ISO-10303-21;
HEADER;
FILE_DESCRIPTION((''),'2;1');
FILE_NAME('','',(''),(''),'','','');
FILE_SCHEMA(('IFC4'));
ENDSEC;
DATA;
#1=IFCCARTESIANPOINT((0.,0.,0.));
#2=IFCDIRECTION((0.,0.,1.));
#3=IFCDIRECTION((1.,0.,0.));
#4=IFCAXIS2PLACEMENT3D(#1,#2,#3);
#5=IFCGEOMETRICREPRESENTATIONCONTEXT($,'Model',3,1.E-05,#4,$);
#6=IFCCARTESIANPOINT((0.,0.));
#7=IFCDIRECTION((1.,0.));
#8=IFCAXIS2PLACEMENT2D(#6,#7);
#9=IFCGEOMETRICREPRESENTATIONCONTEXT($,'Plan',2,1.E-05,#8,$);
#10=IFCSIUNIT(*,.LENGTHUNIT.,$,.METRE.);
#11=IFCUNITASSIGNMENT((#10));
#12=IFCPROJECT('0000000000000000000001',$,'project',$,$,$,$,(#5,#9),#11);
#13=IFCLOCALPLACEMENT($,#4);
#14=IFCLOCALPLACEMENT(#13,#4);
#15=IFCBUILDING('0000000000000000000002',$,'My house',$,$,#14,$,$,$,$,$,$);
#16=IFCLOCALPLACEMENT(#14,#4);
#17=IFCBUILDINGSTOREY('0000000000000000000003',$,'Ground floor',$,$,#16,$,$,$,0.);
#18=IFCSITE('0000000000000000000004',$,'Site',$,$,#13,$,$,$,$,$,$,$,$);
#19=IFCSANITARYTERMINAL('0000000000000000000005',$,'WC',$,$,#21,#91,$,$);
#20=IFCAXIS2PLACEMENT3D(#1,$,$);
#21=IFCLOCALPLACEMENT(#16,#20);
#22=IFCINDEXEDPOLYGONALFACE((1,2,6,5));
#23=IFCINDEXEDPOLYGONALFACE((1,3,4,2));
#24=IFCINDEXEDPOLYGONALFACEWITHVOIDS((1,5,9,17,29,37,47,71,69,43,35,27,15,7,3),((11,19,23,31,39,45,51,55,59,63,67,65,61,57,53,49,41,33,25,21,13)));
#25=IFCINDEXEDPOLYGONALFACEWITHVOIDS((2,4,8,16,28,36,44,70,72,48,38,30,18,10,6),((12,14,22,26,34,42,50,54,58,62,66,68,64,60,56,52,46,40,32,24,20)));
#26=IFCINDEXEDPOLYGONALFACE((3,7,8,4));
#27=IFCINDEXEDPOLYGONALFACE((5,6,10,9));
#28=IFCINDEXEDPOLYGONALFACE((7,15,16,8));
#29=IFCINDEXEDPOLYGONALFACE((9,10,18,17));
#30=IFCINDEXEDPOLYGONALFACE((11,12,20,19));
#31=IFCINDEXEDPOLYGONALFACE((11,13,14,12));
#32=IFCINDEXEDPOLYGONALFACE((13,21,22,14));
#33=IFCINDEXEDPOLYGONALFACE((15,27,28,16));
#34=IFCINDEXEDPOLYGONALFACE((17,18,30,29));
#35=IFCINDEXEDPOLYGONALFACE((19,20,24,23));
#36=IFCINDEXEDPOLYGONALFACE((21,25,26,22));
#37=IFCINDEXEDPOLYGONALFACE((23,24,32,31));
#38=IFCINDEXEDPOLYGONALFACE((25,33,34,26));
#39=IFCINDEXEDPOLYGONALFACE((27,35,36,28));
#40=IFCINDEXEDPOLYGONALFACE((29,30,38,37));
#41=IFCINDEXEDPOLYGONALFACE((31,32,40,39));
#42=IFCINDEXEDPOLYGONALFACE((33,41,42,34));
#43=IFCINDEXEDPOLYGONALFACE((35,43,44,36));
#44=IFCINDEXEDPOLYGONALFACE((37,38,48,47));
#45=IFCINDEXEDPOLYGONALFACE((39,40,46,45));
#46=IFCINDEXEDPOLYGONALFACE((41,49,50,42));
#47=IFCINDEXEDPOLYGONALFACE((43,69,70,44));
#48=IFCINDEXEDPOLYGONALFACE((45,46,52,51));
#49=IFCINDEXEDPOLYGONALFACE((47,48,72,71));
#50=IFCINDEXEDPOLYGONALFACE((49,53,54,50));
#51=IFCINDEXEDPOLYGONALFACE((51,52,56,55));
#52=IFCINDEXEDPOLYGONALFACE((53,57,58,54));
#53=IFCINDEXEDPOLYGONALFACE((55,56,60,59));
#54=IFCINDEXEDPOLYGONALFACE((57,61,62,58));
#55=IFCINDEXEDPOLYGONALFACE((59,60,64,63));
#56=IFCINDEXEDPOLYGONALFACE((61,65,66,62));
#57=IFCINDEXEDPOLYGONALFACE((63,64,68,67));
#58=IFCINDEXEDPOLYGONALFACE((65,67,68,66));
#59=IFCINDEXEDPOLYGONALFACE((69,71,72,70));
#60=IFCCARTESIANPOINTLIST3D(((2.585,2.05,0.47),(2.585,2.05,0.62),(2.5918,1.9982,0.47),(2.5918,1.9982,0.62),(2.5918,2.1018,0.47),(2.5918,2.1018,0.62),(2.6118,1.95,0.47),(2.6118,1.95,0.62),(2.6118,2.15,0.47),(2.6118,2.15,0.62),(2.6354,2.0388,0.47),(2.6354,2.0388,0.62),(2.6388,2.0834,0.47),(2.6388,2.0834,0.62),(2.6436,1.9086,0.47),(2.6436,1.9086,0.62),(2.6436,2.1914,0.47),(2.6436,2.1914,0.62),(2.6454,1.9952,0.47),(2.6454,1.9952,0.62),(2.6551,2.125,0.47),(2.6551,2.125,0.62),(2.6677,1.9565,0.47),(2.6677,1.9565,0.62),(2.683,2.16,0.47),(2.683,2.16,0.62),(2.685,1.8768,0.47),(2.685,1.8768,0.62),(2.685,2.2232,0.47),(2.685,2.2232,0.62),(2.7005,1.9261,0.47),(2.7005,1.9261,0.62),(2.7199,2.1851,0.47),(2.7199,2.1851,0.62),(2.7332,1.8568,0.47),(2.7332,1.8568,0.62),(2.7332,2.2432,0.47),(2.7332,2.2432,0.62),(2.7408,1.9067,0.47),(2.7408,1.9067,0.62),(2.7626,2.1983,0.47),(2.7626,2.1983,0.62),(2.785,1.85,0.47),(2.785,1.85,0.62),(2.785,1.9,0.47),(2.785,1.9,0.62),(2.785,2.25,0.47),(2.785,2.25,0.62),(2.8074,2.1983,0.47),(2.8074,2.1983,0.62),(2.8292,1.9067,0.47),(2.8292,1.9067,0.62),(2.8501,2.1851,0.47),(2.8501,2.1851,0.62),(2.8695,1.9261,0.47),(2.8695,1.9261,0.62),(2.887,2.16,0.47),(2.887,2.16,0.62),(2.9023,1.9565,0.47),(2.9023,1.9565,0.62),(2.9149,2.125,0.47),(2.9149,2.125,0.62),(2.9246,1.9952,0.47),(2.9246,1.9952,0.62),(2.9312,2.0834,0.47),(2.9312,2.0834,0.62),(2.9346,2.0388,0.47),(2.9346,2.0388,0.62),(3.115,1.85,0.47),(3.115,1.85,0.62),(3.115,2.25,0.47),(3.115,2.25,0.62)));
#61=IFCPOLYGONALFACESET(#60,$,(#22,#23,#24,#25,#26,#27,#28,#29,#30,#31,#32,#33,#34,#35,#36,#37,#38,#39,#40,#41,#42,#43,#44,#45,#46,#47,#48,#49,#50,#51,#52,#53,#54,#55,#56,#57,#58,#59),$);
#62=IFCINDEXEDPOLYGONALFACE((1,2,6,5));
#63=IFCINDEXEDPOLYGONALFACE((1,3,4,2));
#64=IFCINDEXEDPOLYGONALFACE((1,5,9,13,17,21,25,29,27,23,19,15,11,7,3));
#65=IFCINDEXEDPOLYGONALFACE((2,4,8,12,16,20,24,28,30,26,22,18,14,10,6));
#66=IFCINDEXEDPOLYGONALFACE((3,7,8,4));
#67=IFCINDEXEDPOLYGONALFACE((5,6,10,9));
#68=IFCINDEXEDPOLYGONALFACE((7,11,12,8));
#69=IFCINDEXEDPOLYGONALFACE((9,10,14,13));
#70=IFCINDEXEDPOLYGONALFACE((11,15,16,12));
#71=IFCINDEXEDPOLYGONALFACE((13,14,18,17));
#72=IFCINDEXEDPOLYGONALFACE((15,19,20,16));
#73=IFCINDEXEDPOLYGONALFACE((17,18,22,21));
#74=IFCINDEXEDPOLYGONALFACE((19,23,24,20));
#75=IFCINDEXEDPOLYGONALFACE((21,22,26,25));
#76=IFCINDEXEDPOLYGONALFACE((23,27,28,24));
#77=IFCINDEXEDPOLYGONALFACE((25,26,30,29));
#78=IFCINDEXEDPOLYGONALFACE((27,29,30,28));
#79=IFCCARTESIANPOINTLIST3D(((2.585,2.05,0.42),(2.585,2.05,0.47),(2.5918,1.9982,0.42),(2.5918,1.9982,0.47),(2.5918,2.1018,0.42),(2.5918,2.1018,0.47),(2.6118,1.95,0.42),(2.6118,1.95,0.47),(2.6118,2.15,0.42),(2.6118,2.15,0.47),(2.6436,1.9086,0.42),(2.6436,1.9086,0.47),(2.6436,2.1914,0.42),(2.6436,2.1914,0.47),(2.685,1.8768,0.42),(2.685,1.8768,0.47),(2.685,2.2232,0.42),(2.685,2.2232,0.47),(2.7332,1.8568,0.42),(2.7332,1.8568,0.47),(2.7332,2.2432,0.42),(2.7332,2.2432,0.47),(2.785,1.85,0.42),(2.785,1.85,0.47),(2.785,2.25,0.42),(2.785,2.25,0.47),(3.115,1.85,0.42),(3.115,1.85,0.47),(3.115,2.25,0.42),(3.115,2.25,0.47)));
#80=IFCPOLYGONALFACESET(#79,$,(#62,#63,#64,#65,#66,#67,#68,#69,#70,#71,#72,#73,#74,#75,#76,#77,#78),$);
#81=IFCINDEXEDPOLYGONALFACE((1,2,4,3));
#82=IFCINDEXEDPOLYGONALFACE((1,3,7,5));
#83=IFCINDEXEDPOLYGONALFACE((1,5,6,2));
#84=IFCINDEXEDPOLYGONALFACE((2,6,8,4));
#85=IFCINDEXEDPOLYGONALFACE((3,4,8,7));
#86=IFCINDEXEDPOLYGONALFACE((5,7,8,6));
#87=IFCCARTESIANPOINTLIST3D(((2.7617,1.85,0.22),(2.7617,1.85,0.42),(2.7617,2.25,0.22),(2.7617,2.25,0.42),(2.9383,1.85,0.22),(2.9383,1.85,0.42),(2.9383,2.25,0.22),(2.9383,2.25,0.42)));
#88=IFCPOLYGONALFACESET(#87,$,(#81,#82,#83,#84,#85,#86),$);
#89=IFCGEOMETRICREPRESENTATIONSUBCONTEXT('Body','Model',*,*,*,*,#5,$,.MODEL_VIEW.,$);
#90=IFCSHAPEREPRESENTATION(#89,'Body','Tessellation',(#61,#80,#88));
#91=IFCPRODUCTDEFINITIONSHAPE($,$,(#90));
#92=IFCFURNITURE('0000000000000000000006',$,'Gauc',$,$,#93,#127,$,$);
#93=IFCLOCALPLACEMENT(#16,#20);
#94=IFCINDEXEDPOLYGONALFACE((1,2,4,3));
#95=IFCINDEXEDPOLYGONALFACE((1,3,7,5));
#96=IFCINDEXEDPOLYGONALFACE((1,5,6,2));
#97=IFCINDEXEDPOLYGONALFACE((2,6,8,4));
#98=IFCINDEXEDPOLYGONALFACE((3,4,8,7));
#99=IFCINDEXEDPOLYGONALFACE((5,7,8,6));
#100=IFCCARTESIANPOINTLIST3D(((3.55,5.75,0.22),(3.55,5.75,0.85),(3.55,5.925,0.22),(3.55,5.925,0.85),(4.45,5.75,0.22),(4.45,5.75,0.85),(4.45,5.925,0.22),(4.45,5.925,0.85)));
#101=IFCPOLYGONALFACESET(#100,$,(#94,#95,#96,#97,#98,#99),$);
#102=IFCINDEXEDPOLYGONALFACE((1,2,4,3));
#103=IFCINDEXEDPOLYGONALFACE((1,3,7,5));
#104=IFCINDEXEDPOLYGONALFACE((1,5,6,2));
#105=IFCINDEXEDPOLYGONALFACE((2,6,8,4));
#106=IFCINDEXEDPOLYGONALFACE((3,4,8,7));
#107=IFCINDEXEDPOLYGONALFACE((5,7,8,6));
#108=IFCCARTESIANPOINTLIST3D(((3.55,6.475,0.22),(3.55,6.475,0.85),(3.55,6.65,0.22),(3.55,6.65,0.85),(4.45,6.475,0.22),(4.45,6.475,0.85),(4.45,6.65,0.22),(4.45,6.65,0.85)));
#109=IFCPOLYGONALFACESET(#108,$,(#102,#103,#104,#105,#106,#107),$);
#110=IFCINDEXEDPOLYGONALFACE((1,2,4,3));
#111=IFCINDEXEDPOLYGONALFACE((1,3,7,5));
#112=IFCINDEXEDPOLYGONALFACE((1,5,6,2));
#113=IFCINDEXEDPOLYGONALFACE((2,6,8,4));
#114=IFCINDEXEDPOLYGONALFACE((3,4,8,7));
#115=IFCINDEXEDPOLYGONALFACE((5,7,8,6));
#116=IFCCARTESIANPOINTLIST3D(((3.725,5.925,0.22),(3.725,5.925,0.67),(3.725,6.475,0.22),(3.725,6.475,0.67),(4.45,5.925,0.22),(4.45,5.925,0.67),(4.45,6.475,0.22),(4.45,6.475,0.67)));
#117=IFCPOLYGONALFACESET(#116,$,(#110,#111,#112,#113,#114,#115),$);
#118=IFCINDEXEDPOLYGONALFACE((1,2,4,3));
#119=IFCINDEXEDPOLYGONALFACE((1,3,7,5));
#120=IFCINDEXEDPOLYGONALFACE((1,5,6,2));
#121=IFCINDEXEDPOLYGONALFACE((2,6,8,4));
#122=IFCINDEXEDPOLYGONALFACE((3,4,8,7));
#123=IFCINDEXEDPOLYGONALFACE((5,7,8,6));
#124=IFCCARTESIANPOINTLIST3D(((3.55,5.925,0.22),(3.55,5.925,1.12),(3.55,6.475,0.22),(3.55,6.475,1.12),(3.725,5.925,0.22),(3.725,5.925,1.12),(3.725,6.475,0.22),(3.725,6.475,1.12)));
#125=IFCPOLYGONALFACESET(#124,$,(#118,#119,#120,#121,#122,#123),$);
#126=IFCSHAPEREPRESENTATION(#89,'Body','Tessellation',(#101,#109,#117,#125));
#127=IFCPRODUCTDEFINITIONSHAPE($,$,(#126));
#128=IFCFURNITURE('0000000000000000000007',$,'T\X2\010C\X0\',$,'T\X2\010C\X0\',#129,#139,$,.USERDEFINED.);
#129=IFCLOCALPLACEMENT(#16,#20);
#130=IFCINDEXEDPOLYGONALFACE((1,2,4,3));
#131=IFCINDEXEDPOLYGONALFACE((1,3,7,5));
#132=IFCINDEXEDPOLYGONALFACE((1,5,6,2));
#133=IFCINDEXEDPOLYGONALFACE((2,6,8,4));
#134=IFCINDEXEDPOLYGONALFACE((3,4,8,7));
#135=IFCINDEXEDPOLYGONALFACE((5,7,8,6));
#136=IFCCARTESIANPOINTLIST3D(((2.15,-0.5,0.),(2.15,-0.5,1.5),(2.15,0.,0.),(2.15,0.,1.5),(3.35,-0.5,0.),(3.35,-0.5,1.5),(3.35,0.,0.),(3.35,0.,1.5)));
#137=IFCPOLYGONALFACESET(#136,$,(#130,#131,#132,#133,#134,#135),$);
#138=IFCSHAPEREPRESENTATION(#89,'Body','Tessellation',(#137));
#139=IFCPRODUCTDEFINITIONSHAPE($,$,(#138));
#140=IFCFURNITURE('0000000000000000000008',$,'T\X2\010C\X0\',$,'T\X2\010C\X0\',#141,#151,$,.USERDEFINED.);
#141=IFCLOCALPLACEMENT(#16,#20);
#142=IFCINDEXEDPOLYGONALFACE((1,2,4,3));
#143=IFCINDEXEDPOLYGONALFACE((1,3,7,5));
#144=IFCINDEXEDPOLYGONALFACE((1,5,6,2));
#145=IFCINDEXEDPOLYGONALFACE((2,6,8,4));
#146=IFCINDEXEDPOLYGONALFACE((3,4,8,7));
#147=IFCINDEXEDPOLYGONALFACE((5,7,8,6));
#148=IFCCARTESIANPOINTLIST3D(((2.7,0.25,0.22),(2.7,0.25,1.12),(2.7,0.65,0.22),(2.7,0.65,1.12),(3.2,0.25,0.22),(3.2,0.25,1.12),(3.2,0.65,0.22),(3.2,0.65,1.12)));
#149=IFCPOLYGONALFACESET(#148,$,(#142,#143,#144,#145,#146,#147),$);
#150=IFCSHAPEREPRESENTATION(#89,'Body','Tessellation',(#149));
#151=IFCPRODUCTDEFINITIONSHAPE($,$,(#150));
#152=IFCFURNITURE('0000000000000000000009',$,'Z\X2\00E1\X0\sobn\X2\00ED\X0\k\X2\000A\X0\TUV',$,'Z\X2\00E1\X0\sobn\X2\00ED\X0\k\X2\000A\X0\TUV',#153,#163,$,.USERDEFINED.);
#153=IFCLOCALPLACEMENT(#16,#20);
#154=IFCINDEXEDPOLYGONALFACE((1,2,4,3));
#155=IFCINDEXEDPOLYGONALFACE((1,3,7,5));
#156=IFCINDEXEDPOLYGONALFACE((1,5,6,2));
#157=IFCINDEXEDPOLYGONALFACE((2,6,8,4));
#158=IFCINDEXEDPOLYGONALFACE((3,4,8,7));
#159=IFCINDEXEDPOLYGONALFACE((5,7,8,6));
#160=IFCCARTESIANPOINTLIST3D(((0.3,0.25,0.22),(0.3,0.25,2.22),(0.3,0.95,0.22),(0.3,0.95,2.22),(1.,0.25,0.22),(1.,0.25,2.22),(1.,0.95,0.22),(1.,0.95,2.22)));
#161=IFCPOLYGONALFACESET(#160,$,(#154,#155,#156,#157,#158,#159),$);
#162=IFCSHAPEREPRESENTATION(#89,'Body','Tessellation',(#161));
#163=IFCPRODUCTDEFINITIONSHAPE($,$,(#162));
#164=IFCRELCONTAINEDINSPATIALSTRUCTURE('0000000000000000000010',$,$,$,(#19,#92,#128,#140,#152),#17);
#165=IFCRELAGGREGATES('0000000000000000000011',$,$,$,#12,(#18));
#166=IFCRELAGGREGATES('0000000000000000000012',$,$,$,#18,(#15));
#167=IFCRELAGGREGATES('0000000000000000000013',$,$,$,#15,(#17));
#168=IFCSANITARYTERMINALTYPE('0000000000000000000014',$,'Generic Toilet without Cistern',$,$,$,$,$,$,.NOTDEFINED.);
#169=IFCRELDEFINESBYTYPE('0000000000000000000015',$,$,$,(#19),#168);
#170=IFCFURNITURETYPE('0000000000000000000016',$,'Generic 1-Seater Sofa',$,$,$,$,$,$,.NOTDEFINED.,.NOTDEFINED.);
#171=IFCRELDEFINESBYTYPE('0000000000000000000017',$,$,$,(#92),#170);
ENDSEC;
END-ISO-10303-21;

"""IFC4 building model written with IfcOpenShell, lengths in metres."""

from ifc_helpers import new_model, entity, si_unit, frame, frame_2d, origin_with_axes, origin_2d_with_axis, place, context, subcontext, project, spatial, line, arc, indexed_curve, circle_curve, outline, extrude, shape, source, transform, mapped, type_object, type_shapes, element, save


model = new_model("IFC4")

# Units and contexts
model_context = context("Model", 3, precision=1e-05, world=origin_with_axes())
plan_context = context("Plan", 2, precision=1e-05, world=origin_2d_with_axis())
body_context_1 = subcontext(model_context, "Body", "Model", "MODEL_VIEW")
body_context_2 = subcontext(plan_context, "Body", "Plan", "PLAN_VIEW")
ifc_project = project(units=[si_unit("LENGTHUNIT", "METRE")], contexts=[model_context, plan_context])

# Site, building, storey
site_placement = place(None, origin_with_axes())
site = spatial("IfcSite", under=ifc_project, at=site_placement, Name="Site")
building_placement = place(site_placement, origin_with_axes())
building = spatial("IfcBuilding", under=site, at=building_placement, Name="My house")
storey_placement = place(building_placement, origin_with_axes())
storey = spatial("IfcBuildingStorey", under=building, at=storey_placement, Name="Ground floor", Elevation=0.0)

# Sanitary terminal
sanitary_terminal_type_1 = type_object("IfcSanitaryTerminalType", Name="Generic Toilet without Cistern", PredefinedType="NOTDEFINED")
shared_shape_1 = source(origin_with_axes(), body_context_1, "Body", "SweptSolid", [
    extrude(outline(indexed_curve([(-0.2, 0.0), (0.2, 0.0), (0.2, -0.33), (0.1414, -0.4714), (0.0, -0.53), (-0.1414, -0.4714), (-0.2, -0.33)], segments=[line(1, 2), line(2, 3), arc(3, 4, 5), arc(5, 6, 7), line(7, 1)]), holes=[circle_curve(frame_2d((0.0, -0.33)), 0.15)]), frame((0.0, 0.0, 0.25), z_axis=(0.0, 0.0, 1.0), x_axis=(1.0, 0.0, 0.0)), (0.0, 0.0, 1.0), 0.15),
    extrude(outline(indexed_curve([(-0.2, 0.0), (0.2, 0.0), (0.2, -0.33), (0.1414, -0.4714), (0.0, -0.53), (-0.1414, -0.4714), (-0.2, -0.33)], segments=[line(1, 2), line(2, 3), arc(3, 4, 5), arc(5, 6, 7), line(7, 1)])), frame((0.0, 0.0, 0.2), z_axis=(0.0, 0.0, 1.0), x_axis=(1.0, 0.0, 0.0)), (0.0, 0.0, 1.0), 0.05),
    extrude(outline(indexed_curve([(-0.2, -0.1767), (0.2, -0.1767), (0.2, -0.3533), (-0.2, -0.3533)], segments=[line(1, 2, 3, 4, 1)])), origin_with_axes(), (0.0, 0.0, 1.0), 0.2),
])
shared_shape_2 = source(origin_with_axes(), body_context_2, "Body", "Curve2D", [
    entity("IfcIndexedPolyCurve", entity("IfcCartesianPointList2D", [[-0.12, 0.0], [0.12, 0.0]])),
    entity("IfcIndexedPolyCurve", entity("IfcCartesianPointList2D", [[0.12, 0.0], [0.2, -0.159]])),
    entity("IfcTrimmedCurve", entity("IfcEllipse", entity("IfcAxis2Placement2D", entity("IfcCartesianPoint", [0.0, -0.159]), entity("IfcDirection", [1.0, 0.0])), 0.2, 0.371), [entity("IfcCartesianPoint", [-0.2, -0.159])], [entity("IfcCartesianPoint", [0.2, -0.159])], True, "CARTESIAN"),
    entity("IfcIndexedPolyCurve", entity("IfcCartesianPointList2D", [[-0.12, 0.0], [-0.2, -0.159]])),
    entity("IfcEllipse", entity("IfcAxis2Placement2D", entity("IfcCartesianPoint", [0.0, -0.2968]), entity("IfcDirection", [1.0, 0.0])), 0.15, 0.1855),
    entity("IfcIndexedPolyCurve", entity("IfcCartesianPointList2D", [[-0.025, -0.2968], [-0.025, -0.2703], [0.025, -0.2703], [0.025, -0.2968]])),
    entity("IfcTrimmedCurve", entity("IfcEllipse", entity("IfcAxis2Placement2D", entity("IfcCartesianPoint", [0.0, -0.2968]), entity("IfcDirection", [1.0, 0.0])), 0.025, 0.0265), [entity("IfcCartesianPoint", [-0.025, -0.2968])], [entity("IfcCartesianPoint", [0.025, -0.2968])], True, "CARTESIAN"),
])
type_shapes(sanitary_terminal_type_1, [shared_shape_1, shared_shape_2])
sanitary_terminal_1_placement = place(storey_placement, frame((3.115, 2.05, 0.22), z_axis=(0.0, 0.0, 1.0), x_axis=(0.0, -1.0, 0.0)))
element("IfcSanitaryTerminal", 1, at=sanitary_terminal_1_placement, inside=storey, type_object=sanitary_terminal_type_1, Name="WC", shapes=[
    shape(body_context_1, "Body", "MappedRepresentation", [mapped(shared_shape_1, transform((0.0, 0.0, 0.0), x_axis=(1.0, 0.0, 0.0), y_axis=(0.0, 1.0, 0.0), z_axis=(0.0, 0.0, 1.0), scale=1.0))]),
    shape(body_context_2, "Body", "MappedRepresentation", [mapped(shared_shape_2, transform((0.0, 0.0, 0.0), x_axis=(1.0, 0.0, 0.0), y_axis=(0.0, 1.0, 0.0), z_axis=(0.0, 0.0, 1.0), scale=1.0))]),
])

# Furniture
furniture_type = type_object("IfcFurnitureType", Name="Generic 1-Seater Sofa", AssemblyPlace="NOTDEFINED", PredefinedType="NOTDEFINED")
shared_shape_3 = source(origin_with_axes(), body_context_1, "Body", "SweptSolid", [
    extrude(outline(indexed_curve([(0.0, 0.0), (0.175, 0.0), (0.175, 0.9), (0.0, 0.9)], segments=[line(1, 2, 3, 4, 1)])), frame((-0.45, -0.9, 0.0), z_axis=(0.0, 0.0, 1.0), x_axis=(1.0, 0.0, 0.0)), (0.0, 0.0, 1.0), 0.63),
    extrude(outline(indexed_curve([(0.0, 0.0), (0.175, 0.0), (0.175, 0.9), (0.0, 0.9)], segments=[line(1, 2, 3, 4, 1)])), frame((0.275, -0.9, 0.0), z_axis=(0.0, 0.0, 1.0), x_axis=(1.0, 0.0, 0.0)), (0.0, 0.0, 1.0), 0.63),
    extrude(outline(indexed_curve([(0.175, 0.0), (0.725, 0.0), (0.725, 0.725), (0.175, 0.725)], segments=[line(1, 2, 3, 4, 1)])), frame((-0.45, -0.9, 0.0), z_axis=(0.0, 0.0, 1.0), x_axis=(1.0, 0.0, 0.0)), (0.0, 0.0, 1.0), 0.45),
    extrude(outline(indexed_curve([(0.175, 0.725), (0.725, 0.725), (0.725, 0.9), (0.175, 0.9)], segments=[line(1, 2, 3, 4, 1)])), frame((-0.45, -0.9, 0.0), z_axis=(0.0, 0.0, 1.0), x_axis=(1.0, 0.0, 0.0)), (0.0, 0.0, 1.0), 0.9),
])
shared_shape_4 = source(origin_with_axes(), body_context_2, "Body", "Curve2D", [
    entity("IfcIndexedPolyCurve", entity("IfcCartesianPointList2D", [[-0.45, -0.9], [-0.275, -0.9], [-0.275, 0.0], [-0.45, 0.0]]), [entity("IfcLineIndex", [1, 2, 3, 4, 1])]),
    entity("IfcIndexedPolyCurve", entity("IfcCartesianPointList2D", [[0.275, -0.9], [0.45, -0.9], [0.45, 0.0], [0.275, 0.0]]), [entity("IfcLineIndex", [1, 2, 3, 4, 1])]),
    entity("IfcIndexedPolyCurve", entity("IfcCartesianPointList2D", [[-0.275, -0.9], [0.275, -0.9], [0.275, -0.175], [-0.275, -0.175]]), [entity("IfcLineIndex", [1, 2, 3, 4, 1])]),
    entity("IfcIndexedPolyCurve", entity("IfcCartesianPointList2D", [[-0.275, -0.175], [0.275, -0.175], [0.275, 0.0], [-0.275, 0.0]]), [entity("IfcLineIndex", [1, 2, 3, 4, 1])]),
])
type_shapes(furniture_type, [shared_shape_3, shared_shape_4])
furniture_1_placement = place(storey_placement, frame((3.55, 6.2, 0.22), z_axis=(0.0, 0.0, 1.0), x_axis=(0.0, 1.0, 0.0)))
element("IfcFurniture", 2, at=furniture_1_placement, inside=storey, type_object=furniture_type, Name="Gauc", shapes=[
    shape(body_context_1, "Body", "MappedRepresentation", [mapped(shared_shape_3, transform((0.0, 0.0, 0.0), x_axis=(1.0, 0.0, 0.0), y_axis=(0.0, 1.0, 0.0), z_axis=(0.0, 0.0, 1.0), scale=1.0))]),
    shape(body_context_2, "Body", "MappedRepresentation", [mapped(shared_shape_4, transform((0.0, 0.0, 0.0), x_axis=(1.0, 0.0, 0.0), y_axis=(0.0, 1.0, 0.0), z_axis=(0.0, 0.0, 1.0), scale=1.0))]),
])
furniture_2_placement = place(storey_placement, frame((2.75, -0.25, 0.0), z_axis=(0.0, 0.0, 1.0), x_axis=(1.0, 0.0, 0.0)))
element("IfcFurniture", 3, at=furniture_2_placement, inside=storey, Name="TČ", ObjectType="TČ", PredefinedType="USERDEFINED", shapes=[
    shape(body_context_1, "Body", "SweptSolid", [extrude(outline(indexed_curve([(-0.6, -0.25), (0.6, -0.25), (0.6, 0.25), (-0.6, 0.25)])), None, (0.0, 0.0, 1.0), 1.5)]),
    shape(body_context_2, "Body", "Curve2D", [entity("IfcIndexedPolyCurve", entity("IfcCartesianPointList2D", [[-0.6, -0.25], [0.6, -0.25], [0.6, 0.25], [-0.6, 0.25], [-0.6, -0.25]]), None, False)]),
])
furniture_3_placement = place(storey_placement, frame((2.95, 0.45, 0.22), z_axis=(0.0, 0.0, 1.0), x_axis=(1.0, 0.0, 0.0)))
element("IfcFurniture", 4, at=furniture_3_placement, inside=storey, Name="TČ", ObjectType="TČ", PredefinedType="USERDEFINED", shapes=[
    shape(body_context_1, "Body", "SweptSolid", [extrude(outline(indexed_curve([(-0.25, -0.2), (0.25, -0.2), (0.25, 0.2), (-0.25, 0.2)])), None, (0.0, 0.0, 1.0), 0.9)]),
    shape(body_context_2, "Body", "Curve2D", [entity("IfcIndexedPolyCurve", entity("IfcCartesianPointList2D", [[-0.25, -0.2], [0.25, -0.2], [0.25, 0.2], [-0.25, 0.2], [-0.25, -0.2]]), None, False)]),
])
furniture_4_placement = place(storey_placement, frame((0.65, 0.6, 0.22), z_axis=(0.0, 0.0, 1.0), x_axis=(1.0, 0.0, 0.0)))
element("IfcFurniture", 5, at=furniture_4_placement, inside=storey, Name="Zásobník\nTUV", ObjectType="Zásobník\nTUV", PredefinedType="USERDEFINED", shapes=[
    shape(body_context_1, "Body", "SweptSolid", [extrude(outline(indexed_curve([(-0.35, -0.35), (0.35, -0.35), (0.35, 0.35), (-0.35, 0.35)])), None, (0.0, 0.0, 1.0), 2.0)]),
    shape(body_context_2, "Body", "Curve2D", [entity("IfcIndexedPolyCurve", entity("IfcCartesianPointList2D", [[-0.35, -0.35], [0.35, -0.35], [0.35, 0.35], [-0.35, 0.35], [-0.35, -0.35]]), None, False)]),
])

save(model, "model.ifc")
